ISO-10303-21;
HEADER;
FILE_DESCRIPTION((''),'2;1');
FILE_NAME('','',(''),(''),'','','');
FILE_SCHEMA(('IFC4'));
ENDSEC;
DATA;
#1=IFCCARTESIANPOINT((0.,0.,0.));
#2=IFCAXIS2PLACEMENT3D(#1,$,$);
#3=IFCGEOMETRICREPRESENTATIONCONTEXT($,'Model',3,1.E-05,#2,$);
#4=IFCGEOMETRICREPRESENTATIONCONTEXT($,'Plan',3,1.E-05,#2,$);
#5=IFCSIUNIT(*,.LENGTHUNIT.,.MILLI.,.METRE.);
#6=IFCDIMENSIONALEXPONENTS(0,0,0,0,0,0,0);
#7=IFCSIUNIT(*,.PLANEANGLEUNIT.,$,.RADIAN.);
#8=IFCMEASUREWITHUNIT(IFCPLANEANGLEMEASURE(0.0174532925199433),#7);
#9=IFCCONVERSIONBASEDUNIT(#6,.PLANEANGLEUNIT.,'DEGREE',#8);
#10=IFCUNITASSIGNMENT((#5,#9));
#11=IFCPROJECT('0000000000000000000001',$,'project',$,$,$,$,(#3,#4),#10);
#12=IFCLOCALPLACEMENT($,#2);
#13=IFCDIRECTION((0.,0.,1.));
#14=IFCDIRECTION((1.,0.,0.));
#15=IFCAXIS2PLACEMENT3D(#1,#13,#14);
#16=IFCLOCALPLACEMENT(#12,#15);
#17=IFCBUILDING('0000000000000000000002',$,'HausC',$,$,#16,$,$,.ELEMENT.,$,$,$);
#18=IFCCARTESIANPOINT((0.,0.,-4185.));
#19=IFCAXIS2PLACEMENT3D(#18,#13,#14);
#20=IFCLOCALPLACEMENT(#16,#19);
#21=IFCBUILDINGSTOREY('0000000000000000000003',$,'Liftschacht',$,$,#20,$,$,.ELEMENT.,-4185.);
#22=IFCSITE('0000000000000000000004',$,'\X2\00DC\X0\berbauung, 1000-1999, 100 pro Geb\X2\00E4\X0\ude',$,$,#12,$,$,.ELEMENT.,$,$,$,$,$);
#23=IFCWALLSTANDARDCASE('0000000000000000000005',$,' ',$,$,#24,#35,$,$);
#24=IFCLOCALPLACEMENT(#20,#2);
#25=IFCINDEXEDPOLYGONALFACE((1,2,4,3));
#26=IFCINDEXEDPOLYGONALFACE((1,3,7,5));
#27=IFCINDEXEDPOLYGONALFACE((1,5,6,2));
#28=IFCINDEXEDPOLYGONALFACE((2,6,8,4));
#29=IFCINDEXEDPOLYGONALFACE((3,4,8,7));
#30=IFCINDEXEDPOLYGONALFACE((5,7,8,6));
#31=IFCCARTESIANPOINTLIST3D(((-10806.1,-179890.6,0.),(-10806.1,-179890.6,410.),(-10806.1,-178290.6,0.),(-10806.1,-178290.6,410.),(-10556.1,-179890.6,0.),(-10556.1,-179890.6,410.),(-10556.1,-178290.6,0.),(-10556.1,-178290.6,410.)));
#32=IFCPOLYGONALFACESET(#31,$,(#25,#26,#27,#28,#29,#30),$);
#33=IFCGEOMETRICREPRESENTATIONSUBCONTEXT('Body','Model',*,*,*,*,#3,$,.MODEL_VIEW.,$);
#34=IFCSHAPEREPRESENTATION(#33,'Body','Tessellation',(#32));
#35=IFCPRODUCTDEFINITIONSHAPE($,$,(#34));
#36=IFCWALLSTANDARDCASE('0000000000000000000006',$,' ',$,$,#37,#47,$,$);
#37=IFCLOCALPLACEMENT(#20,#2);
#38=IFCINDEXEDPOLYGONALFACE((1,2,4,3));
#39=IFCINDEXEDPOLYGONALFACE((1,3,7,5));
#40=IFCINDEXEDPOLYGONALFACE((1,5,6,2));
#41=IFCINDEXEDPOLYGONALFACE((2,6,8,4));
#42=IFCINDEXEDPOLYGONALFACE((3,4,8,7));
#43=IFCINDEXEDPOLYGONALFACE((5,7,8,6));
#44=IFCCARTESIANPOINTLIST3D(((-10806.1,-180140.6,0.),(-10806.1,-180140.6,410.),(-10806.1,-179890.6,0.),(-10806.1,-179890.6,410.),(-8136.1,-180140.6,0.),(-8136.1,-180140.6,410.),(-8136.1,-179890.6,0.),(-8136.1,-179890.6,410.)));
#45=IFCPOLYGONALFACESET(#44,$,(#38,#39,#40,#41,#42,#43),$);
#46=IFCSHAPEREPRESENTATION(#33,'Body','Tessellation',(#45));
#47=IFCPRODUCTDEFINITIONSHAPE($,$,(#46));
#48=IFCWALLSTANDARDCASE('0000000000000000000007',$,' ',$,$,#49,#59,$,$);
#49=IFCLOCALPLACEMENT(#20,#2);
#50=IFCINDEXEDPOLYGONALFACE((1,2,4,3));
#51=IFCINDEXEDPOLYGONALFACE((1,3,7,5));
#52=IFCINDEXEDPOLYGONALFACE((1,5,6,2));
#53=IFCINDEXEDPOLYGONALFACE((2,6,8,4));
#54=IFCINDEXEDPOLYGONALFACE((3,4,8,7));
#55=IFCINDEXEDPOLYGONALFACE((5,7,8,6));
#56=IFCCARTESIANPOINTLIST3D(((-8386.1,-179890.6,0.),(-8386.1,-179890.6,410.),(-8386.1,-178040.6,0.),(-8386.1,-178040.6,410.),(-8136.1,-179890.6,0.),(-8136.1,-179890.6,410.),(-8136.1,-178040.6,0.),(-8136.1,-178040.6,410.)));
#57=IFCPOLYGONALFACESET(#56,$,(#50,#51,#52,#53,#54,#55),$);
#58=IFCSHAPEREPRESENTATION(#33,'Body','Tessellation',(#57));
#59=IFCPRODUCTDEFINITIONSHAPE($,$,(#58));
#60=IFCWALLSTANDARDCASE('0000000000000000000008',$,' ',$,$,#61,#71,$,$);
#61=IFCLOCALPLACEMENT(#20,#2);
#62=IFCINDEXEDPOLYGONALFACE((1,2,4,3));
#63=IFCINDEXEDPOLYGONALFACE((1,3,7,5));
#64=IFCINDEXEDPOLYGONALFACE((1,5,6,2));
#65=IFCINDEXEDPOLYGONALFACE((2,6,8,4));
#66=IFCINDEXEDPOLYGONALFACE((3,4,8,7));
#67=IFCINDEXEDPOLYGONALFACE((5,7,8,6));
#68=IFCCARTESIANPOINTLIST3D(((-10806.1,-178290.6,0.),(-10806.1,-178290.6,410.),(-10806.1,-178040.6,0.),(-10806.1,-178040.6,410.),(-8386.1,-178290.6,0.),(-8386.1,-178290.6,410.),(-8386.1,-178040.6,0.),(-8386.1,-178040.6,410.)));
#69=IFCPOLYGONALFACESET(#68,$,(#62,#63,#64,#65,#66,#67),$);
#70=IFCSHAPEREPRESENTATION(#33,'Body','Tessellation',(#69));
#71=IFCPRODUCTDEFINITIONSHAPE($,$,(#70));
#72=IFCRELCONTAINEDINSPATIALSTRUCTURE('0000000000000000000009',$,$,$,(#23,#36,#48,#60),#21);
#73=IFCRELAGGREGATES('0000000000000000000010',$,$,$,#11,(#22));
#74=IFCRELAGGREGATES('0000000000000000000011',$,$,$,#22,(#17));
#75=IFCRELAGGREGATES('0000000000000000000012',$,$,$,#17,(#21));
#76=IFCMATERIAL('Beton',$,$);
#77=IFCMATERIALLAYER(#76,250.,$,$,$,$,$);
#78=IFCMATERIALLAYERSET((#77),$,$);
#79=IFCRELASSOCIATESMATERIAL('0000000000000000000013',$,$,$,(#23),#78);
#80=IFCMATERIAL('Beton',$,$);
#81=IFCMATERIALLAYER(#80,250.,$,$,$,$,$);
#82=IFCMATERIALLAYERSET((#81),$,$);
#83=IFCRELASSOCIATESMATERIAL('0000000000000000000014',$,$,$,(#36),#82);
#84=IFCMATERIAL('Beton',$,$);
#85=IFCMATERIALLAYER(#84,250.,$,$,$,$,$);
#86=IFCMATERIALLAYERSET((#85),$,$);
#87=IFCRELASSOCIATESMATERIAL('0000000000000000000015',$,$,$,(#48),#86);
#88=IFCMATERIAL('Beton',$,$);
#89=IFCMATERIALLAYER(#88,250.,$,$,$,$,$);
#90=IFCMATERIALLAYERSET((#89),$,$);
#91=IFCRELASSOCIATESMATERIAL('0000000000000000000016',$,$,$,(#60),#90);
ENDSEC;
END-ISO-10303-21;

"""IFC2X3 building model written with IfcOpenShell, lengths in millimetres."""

from ifc_helpers import new_model, entity, si_unit, converted_unit, frame, frame_2d, origin, origin_with_axes, place, context, subcontext, project, spatial, rectangle, extrude, material, layer, layer_set, layer_usage, element, save


model = new_model("IFC2X3")

# Units and contexts
model_context = context("Model", 3, precision=1e-05, world=origin())
plan_context = context("Plan", 3, precision=1e-05, world=origin())
body_context = subcontext(model_context, "Body", "Model", "MODEL_VIEW")
ifc_project = project(units=[si_unit("LENGTHUNIT", "METRE", prefix="MILLI"), converted_unit("PLANEANGLEUNIT", "DEGREE", entity("IfcPlaneAngleMeasure", 0.0174532925199433), si_unit("PLANEANGLEUNIT", "RADIAN"), dimensions=[0, 0, 0, 0, 0, 0, 0])], contexts=[model_context, plan_context])

# Site, building, storey
site_placement = place(None, origin())
site = spatial("IfcSite", under=ifc_project, at=site_placement, Name="Überbauung, 1000-1999, 100 pro Gebäude", CompositionType="ELEMENT")
building_placement = place(site_placement, origin_with_axes())
building = spatial("IfcBuilding", under=site, at=building_placement, Name="HausC", CompositionType="ELEMENT")
storey_placement = place(building_placement, frame((0.0, 0.0, -4185.0), z_axis=(0.0, 0.0, 1.0), x_axis=(1.0, 0.0, 0.0)))
storey = spatial("IfcBuildingStorey", under=building, at=storey_placement, Name="Liftschacht", CompositionType="ELEMENT", Elevation=-4185.0)

# Walls
ifc_material_1 = material(Name="Beton")
ifc_layer_1 = layer(ifc_material_1, 250.0)
ifc_layer_set_1 = layer_set([ifc_layer_1])
ifc_layer_usage_1 = layer_usage(ifc_layer_set_1, "AXIS2", "POSITIVE", 0.0)
wall_1_placement = place(storey_placement, frame((-10806.1, -178290.6, 0.0), z_axis=(0.0, 0.0, 1.0), x_axis=(0.0, -1.0, 0.0)))
element("IfcWallStandardCase", 1, at=wall_1_placement, inside=storey, material=ifc_layer_usage_1, Name=" ", context=body_context, shape_type="SweptSolid", body=[
    extrude(rectangle(XDim=1600.0, YDim=250.0, at=frame_2d((800.0, 125.0), x_axis=(1.0, 0.0))), origin_with_axes(), (0.0, 0.0, 1.0), 410.0),
])
ifc_material_2 = material(Name="Beton")
ifc_layer_2 = layer(ifc_material_2, 250.0)
ifc_layer_set_2 = layer_set([ifc_layer_2])
ifc_layer_usage_2 = layer_usage(ifc_layer_set_2, "AXIS2", "POSITIVE", 0.0)
wall_2_placement = place(storey_placement, frame((-10806.1, -180140.6, 0.0), z_axis=(0.0, 0.0, 1.0), x_axis=(1.0, 0.0, 0.0)))
element("IfcWallStandardCase", 2, at=wall_2_placement, inside=storey, material=ifc_layer_usage_2, Name=" ", context=body_context, shape_type="SweptSolid", body=[
    extrude(rectangle(XDim=2670.0, YDim=250.0, at=frame_2d((1335.0, 125.0), x_axis=(1.0, 0.0))), origin_with_axes(), (0.0, 0.0, 1.0), 410.0),
])
ifc_material_3 = material(Name="Beton")
ifc_layer_3 = layer(ifc_material_3, 250.0)
ifc_layer_set_3 = layer_set([ifc_layer_3])
ifc_layer_usage_3 = layer_usage(ifc_layer_set_3, "AXIS2", "POSITIVE", 0.0)
wall_3_placement = place(storey_placement, frame((-8136.1, -179890.6, 0.0), z_axis=(0.0, 0.0, 1.0), x_axis=(0.0, 1.0, 0.0)))
element("IfcWallStandardCase", 3, at=wall_3_placement, inside=storey, material=ifc_layer_usage_3, Name=" ", context=body_context, shape_type="SweptSolid", body=[
    extrude(rectangle(XDim=1850.0, YDim=250.0, at=frame_2d((925.0, 125.0), x_axis=(1.0, 0.0))), origin_with_axes(), (0.0, 0.0, 1.0), 410.0),
])
ifc_material_4 = material(Name="Beton")
ifc_layer_4 = layer(ifc_material_4, 250.0)
ifc_layer_set_4 = layer_set([ifc_layer_4])
ifc_layer_usage_4 = layer_usage(ifc_layer_set_4, "AXIS2", "POSITIVE", 0.0)
wall_4_placement = place(storey_placement, frame((-8386.1, -178040.6, 0.0), z_axis=(0.0, 0.0, 1.0), x_axis=(-1.0, 0.0, 0.0)))
element("IfcWallStandardCase", 4, at=wall_4_placement, inside=storey, material=ifc_layer_usage_4, Name=" ", context=body_context, shape_type="SweptSolid", body=[
    extrude(rectangle(XDim=2420.0, YDim=250.0, at=frame_2d((1210.0, 125.0), x_axis=(1.0, 0.0))), origin_with_axes(), (0.0, 0.0, 1.0), 410.0),
])

save(model, "model.ifc")
